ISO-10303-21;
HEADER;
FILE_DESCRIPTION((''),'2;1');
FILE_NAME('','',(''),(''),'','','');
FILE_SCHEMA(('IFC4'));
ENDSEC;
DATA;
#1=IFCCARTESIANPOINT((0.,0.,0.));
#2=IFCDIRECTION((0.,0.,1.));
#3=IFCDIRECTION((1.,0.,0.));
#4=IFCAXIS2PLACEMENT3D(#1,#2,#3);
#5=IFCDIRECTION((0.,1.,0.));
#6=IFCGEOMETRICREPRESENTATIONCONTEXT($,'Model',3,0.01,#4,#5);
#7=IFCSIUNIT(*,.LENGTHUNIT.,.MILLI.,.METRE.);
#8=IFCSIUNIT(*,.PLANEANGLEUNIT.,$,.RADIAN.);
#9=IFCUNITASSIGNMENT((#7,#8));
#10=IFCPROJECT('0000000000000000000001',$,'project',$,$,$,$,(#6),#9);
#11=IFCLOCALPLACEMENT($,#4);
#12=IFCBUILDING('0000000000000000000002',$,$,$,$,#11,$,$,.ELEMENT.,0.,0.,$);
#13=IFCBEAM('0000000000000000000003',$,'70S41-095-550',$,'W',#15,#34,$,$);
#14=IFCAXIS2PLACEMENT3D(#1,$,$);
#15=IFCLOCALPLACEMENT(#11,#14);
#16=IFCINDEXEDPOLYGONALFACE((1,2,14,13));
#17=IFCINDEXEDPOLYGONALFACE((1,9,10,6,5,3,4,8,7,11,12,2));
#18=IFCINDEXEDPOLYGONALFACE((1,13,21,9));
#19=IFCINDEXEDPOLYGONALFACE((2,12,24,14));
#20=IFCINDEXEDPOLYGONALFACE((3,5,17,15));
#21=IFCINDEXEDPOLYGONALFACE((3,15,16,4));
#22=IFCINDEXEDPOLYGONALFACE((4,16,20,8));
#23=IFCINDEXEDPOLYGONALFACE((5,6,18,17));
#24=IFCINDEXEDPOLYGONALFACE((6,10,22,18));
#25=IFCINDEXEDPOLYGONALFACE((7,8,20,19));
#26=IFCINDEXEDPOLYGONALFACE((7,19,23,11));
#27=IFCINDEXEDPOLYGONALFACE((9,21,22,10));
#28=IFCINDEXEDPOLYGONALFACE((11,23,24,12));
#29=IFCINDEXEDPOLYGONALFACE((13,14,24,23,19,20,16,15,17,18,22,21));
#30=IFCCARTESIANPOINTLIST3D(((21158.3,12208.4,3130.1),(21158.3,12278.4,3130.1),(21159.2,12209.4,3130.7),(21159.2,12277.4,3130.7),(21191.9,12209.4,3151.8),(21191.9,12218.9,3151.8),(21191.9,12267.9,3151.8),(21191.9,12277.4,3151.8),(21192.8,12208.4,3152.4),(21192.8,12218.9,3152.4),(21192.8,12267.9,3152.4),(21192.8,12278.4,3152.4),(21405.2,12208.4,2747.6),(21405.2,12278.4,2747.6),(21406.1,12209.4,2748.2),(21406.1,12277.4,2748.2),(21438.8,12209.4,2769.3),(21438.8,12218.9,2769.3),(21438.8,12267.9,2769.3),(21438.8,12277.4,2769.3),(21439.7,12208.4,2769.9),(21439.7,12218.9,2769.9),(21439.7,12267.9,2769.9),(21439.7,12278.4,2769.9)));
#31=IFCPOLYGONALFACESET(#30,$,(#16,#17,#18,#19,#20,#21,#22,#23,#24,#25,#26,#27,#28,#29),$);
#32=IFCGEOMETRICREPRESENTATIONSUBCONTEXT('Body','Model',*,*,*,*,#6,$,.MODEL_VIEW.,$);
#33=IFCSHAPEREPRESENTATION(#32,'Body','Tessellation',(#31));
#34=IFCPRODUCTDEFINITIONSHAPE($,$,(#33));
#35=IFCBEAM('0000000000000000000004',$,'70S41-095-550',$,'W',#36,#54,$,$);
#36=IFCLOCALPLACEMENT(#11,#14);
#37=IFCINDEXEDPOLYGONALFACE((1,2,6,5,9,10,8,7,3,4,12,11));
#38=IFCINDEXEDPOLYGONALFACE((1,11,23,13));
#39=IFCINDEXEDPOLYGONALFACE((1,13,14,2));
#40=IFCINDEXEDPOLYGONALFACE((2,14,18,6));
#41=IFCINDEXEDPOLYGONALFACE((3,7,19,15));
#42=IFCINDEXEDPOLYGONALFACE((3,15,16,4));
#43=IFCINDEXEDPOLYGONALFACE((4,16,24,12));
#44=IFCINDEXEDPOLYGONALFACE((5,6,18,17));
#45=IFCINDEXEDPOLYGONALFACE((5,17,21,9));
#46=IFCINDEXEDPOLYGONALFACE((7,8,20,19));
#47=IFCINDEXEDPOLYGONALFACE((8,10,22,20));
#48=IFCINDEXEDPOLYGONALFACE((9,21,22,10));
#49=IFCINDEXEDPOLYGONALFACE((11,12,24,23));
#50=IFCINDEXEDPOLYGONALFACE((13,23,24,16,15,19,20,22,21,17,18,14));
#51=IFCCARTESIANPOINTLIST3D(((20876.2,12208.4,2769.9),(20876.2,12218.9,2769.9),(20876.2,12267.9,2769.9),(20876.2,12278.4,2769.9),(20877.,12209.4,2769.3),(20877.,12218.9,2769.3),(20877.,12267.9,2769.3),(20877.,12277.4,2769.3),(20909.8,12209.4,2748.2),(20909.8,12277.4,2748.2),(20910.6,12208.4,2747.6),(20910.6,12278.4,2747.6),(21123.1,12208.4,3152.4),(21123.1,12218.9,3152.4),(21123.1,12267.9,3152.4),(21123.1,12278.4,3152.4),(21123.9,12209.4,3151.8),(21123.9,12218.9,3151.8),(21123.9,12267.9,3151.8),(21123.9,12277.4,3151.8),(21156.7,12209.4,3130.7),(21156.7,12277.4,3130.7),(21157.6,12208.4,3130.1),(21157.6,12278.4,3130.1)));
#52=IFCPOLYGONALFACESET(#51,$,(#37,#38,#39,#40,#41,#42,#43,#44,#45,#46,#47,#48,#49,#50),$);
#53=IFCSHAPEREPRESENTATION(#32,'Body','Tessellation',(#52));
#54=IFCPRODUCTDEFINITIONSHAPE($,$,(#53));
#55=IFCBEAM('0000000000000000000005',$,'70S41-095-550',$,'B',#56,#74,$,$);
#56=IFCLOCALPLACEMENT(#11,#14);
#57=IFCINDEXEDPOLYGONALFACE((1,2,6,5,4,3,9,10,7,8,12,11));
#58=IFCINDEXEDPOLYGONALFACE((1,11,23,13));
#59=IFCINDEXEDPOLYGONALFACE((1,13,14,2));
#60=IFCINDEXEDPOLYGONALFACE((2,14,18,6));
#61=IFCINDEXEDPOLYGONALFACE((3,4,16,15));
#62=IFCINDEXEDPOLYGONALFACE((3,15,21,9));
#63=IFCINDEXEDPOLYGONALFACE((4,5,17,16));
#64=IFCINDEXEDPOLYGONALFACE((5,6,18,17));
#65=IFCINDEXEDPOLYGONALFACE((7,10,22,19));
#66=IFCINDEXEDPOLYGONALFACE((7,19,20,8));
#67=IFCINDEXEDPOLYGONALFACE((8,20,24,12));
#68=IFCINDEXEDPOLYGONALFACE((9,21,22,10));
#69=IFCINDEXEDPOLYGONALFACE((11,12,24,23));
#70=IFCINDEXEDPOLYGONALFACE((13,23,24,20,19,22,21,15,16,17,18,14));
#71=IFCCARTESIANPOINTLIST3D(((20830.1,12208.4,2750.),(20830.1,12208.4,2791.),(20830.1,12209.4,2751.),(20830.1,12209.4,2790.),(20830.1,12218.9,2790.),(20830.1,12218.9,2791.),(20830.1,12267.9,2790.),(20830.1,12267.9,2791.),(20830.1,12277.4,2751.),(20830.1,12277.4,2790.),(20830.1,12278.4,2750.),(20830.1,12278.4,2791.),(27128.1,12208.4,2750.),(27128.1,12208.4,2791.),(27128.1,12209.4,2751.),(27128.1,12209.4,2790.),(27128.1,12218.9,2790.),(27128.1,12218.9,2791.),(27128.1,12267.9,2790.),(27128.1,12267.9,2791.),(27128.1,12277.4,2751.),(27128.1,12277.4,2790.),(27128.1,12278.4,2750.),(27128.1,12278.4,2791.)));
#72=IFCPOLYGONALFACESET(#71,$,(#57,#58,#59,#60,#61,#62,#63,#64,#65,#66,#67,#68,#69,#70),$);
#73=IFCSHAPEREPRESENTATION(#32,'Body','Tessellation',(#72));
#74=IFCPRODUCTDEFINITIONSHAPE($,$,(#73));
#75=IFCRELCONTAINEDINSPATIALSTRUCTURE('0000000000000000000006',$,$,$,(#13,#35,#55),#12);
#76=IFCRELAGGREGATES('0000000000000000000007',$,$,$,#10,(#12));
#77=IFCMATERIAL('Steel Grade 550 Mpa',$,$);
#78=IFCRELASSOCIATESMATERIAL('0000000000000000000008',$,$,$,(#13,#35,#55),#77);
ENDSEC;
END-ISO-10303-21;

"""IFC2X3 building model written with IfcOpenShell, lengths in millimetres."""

from ifc_helpers import new_model, si_unit, direction, frame, origin, origin_with_axes, origin_2d_with_axis, place, context, subcontext, project, spatial, c_section, extrude, source, transform, mapped, material, element, save


model = new_model("IFC2X3")

# Units and contexts
model_context = context("Model", 3, precision=0.01, world=origin_with_axes(), true_north=direction((0.0, 1.0, 0.0)))
body_context = subcontext(model_context, "Body", "Model", "MODEL_VIEW")
ifc_project = project(units=[si_unit("LENGTHUNIT", "METRE", prefix="MILLI"), si_unit("PLANEANGLEUNIT", "RADIAN")], contexts=[model_context])

# Building
building_placement = place(None, origin_with_axes())
building = spatial("IfcBuilding", under=ifc_project, at=building_placement, CompositionType="ELEMENT", ElevationOfRefHeight=0.0, ElevationOfTerrain=0.0)

# Beams
ifc_material = material(Name="Steel Grade 550 Mpa")
shared_shape_1 = source(origin(), body_context, "Body", "SweptSolid", [
    extrude(c_section(Depth=70.0, Width=41.0, WallThickness=1.0, Girth=10.5, at=origin_2d_with_axis()), origin_with_axes(), (0.0, 0.0, 1.0), 455.3),
])
beam_1_placement = place(None, frame((21175.5, 12243.4, 3141.3), z_axis=(0.54232, 0.0, -0.840172), x_axis=(0.840172, 0.0, 0.54232)))
element("IfcBeam", 1, at=beam_1_placement, inside=building, material=ifc_material, Name="70S41-095-550", ObjectType="W", context=body_context, shape_type="MappedRepresentation", body=[
    mapped(shared_shape_1, transform((0.0, 0.0, 0.0), scale=1.0)),
])
shared_shape_2 = source(origin(), body_context, "Body", "SweptSolid", [
    extrude(c_section(Depth=70.0, Width=41.0, WallThickness=1.0, Girth=10.5, at=origin_2d_with_axis()), origin_with_axes(), (0.0, 0.0, 1.0), 455.3),
])
beam_2_placement = place(None, frame((20893.4, 12243.4, 2758.7), z_axis=(0.54232, 0.0, 0.840172), x_axis=(-0.840172, 0.0, 0.54232)))
element("IfcBeam", 2, at=beam_2_placement, inside=building, material=ifc_material, Name="70S41-095-550", ObjectType="W", context=body_context, shape_type="MappedRepresentation", body=[
    mapped(shared_shape_2, transform((0.0, 0.0, 0.0), scale=1.0)),
])
shared_shape_3 = source(origin(), body_context, "Body", "SweptSolid", [
    extrude(c_section(Depth=70.0, Width=41.0, WallThickness=1.0, Girth=10.5, at=origin_2d_with_axis()), origin_with_axes(), (0.0, 0.0, 1.0), 6298.0),
])
beam_3_placement = place(None, frame((20830.1, 12243.4, 2770.5), z_axis=(1.0, 0.0, 0.0), x_axis=(0.0, 0.0, 1.0)))
element("IfcBeam", 3, at=beam_3_placement, inside=building, material=ifc_material, Name="70S41-095-550", ObjectType="B", context=body_context, shape_type="MappedRepresentation", body=[
    mapped(shared_shape_3, transform((0.0, 0.0, 0.0), scale=1.0)),
])

save(model, "model.ifc")
